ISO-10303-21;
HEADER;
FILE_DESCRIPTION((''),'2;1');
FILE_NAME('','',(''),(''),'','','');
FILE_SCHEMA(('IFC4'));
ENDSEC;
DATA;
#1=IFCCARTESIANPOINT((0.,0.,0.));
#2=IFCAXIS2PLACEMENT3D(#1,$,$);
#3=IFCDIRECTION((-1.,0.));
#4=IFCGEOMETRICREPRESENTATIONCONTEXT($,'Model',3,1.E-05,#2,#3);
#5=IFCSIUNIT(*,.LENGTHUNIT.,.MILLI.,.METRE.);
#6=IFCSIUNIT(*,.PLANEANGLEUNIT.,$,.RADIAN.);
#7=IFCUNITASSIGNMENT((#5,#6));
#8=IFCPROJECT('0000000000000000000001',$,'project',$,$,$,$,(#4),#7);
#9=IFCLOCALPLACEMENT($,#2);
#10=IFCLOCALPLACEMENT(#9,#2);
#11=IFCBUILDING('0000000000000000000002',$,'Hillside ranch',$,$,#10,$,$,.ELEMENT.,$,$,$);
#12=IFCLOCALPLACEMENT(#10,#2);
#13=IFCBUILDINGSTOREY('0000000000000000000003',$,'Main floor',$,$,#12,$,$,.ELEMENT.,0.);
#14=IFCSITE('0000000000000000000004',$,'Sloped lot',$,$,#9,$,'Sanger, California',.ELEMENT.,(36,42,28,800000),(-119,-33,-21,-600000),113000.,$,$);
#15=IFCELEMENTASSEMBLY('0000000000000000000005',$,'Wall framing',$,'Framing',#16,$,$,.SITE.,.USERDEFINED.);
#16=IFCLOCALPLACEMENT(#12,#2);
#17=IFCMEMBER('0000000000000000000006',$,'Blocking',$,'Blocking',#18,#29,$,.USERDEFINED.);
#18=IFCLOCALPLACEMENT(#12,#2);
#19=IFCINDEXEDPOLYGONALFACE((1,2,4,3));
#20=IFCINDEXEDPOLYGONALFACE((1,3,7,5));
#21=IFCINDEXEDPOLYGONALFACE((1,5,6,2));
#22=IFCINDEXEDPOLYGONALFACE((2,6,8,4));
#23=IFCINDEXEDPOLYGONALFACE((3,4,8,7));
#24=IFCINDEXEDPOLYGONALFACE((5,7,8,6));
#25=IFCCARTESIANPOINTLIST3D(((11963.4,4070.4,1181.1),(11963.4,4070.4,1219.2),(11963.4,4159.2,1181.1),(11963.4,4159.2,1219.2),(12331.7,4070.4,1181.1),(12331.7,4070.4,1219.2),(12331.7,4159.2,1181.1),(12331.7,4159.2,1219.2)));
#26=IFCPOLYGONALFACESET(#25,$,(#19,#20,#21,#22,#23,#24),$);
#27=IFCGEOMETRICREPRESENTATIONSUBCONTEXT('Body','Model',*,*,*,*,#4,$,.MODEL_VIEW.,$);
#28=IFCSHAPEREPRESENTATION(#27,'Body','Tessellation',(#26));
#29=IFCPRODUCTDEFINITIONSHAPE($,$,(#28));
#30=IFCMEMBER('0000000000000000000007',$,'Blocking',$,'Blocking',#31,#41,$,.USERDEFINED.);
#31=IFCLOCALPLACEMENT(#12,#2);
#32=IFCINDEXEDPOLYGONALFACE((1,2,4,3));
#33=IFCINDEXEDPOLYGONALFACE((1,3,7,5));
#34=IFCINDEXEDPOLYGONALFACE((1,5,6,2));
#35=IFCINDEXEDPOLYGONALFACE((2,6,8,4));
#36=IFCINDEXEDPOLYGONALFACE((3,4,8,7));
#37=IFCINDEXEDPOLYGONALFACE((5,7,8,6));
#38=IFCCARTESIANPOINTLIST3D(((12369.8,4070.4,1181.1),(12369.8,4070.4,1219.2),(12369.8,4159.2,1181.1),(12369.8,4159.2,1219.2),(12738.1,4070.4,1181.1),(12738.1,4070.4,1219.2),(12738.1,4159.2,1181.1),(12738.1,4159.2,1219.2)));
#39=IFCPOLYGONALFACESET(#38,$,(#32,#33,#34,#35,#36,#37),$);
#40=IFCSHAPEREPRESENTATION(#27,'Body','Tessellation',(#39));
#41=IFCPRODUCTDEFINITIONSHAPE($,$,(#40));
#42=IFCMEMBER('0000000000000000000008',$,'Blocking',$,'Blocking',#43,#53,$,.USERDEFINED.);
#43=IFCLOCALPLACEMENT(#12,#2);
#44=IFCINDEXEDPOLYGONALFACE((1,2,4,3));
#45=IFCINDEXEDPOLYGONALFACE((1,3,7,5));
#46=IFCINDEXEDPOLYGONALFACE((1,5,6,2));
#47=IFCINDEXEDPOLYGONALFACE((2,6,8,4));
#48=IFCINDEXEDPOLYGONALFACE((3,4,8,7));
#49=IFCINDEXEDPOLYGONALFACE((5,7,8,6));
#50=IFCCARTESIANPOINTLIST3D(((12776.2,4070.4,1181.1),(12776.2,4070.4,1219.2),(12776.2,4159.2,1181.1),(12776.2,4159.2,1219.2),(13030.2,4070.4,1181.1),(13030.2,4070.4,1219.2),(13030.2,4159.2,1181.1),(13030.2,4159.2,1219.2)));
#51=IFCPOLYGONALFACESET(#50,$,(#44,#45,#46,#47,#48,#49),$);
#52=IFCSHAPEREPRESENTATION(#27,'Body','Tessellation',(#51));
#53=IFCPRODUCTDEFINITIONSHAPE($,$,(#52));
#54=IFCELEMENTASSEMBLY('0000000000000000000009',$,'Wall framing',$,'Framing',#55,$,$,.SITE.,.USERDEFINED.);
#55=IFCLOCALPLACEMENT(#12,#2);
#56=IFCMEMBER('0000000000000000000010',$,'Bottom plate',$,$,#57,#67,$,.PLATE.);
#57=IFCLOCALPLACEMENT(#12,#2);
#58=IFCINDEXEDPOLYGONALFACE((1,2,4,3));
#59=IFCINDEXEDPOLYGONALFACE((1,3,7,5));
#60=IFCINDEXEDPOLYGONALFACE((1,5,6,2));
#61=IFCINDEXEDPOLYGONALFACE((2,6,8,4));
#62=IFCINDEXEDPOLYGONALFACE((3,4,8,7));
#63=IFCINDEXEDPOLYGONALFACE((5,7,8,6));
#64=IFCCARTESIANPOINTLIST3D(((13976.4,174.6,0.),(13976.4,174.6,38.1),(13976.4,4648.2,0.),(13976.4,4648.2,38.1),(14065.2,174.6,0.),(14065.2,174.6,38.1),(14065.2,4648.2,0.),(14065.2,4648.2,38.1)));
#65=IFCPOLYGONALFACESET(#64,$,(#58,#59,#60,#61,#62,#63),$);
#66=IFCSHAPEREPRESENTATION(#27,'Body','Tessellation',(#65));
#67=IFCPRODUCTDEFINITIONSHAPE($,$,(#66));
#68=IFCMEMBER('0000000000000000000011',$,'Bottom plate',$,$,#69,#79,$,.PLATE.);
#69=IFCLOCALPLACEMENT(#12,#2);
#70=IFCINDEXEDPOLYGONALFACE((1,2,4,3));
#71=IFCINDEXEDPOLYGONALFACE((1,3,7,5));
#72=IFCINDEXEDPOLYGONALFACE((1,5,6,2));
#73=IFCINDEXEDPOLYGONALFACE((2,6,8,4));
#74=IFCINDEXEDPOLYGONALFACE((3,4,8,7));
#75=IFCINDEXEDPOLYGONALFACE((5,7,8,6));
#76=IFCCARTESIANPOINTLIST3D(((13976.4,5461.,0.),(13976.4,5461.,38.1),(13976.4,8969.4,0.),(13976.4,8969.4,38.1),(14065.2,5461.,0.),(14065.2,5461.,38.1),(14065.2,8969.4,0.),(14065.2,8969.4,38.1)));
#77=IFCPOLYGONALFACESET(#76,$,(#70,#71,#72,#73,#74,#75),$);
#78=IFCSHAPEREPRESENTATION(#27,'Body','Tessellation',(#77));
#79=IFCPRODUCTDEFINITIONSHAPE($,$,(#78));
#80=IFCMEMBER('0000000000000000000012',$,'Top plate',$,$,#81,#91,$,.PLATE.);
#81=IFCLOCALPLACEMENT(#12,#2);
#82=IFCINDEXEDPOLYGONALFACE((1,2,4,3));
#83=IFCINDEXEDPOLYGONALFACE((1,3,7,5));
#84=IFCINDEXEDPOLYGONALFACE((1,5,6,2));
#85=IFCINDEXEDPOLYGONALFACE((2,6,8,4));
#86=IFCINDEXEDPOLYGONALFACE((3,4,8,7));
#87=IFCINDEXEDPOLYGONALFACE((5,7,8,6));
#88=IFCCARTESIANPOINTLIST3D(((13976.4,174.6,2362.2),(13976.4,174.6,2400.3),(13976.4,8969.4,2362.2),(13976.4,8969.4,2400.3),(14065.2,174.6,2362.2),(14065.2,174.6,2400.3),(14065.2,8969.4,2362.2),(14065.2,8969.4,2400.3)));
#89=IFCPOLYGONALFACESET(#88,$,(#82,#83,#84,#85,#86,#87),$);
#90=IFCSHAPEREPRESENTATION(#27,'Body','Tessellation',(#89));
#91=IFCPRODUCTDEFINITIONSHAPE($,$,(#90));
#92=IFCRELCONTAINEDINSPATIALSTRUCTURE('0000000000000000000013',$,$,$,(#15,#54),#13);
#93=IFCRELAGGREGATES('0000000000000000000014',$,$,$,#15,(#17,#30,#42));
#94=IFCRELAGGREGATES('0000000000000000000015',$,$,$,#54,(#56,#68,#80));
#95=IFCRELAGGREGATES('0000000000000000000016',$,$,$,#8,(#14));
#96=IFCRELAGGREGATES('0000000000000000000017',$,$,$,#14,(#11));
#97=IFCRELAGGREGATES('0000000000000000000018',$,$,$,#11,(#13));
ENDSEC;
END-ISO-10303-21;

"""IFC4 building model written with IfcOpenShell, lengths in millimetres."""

from ifc_helpers import new_model, si_unit, direction, frame, origin, origin_with_axes, place, context, subcontext, project, spatial, polyline, outline, extrude, element, aggregate, save


model = new_model("IFC4")

# Units and contexts
model_context = context("Model", 3, precision=1e-05, world=origin(), true_north=direction((-1.0, 0.0)))
body_context = subcontext(model_context, "Body", "Model", "MODEL_VIEW")
ifc_project = project(units=[si_unit("LENGTHUNIT", "METRE", prefix="MILLI"), si_unit("PLANEANGLEUNIT", "RADIAN")], contexts=[model_context])

# Site, building, storey
site_placement = place(None, origin())
site = spatial("IfcSite", under=ifc_project, at=site_placement, Name="Sloped lot", LongName="Sanger, California", CompositionType="ELEMENT", RefLatitude=(36, 42, 28, 800000), RefLongitude=(-119, -33, -21, -600000), RefElevation=113000.0)
building_placement = place(site_placement, origin())
building = spatial("IfcBuilding", under=site, at=building_placement, Name="Hillside ranch", CompositionType="ELEMENT")
storey_placement = place(building_placement, origin())
storey = spatial("IfcBuildingStorey", under=building, at=storey_placement, Name="Main floor", CompositionType="ELEMENT", Elevation=0.0)

# Element assemblies, members
assembly_1_placement = place(storey_placement, origin_with_axes())
assembly_1 = element("IfcElementAssembly", 1, at=assembly_1_placement, inside=storey, Name="Wall framing", ObjectType="Framing", AssemblyPlace="SITE", PredefinedType="USERDEFINED")
member_1_placement = place(storey_placement, origin_with_axes())
member_1 = element("IfcMember", 2, at=member_1_placement, Name="Blocking", ObjectType="Blocking", PredefinedType="USERDEFINED", context=body_context, shape_type="SweptSolid", body=[
    extrude(outline(polyline([(0.0, 0.0), (368.3, 0.0), (368.3, 88.9), (0.0, 88.9), (0.0, 0.0)])), frame((11963.4, 4070.3, 1181.1), z_axis=(0.0, 0.0, 1.0), x_axis=(1.0, 0.0, 0.0)), (0.0, 0.0, 1.0), 38.1),
])
member_2_placement = place(storey_placement, origin_with_axes())
member_2 = element("IfcMember", 3, at=member_2_placement, Name="Blocking", ObjectType="Blocking", PredefinedType="USERDEFINED", context=body_context, shape_type="SweptSolid", body=[
    extrude(outline(polyline([(0.0, 0.0), (368.3, 0.0), (368.3, 88.9), (0.0, 88.9), (0.0, 0.0)])), frame((12369.8, 4070.3, 1181.1), z_axis=(0.0, 0.0, 1.0), x_axis=(1.0, 0.0, 0.0)), (0.0, 0.0, 1.0), 38.1),
])
member_3_placement = place(storey_placement, origin_with_axes())
member_3 = element("IfcMember", 4, at=member_3_placement, Name="Blocking", ObjectType="Blocking", PredefinedType="USERDEFINED", context=body_context, shape_type="SweptSolid", body=[
    extrude(outline(polyline([(0.0, 0.0), (254.0, 0.0), (254.0, 88.9), (0.0, 88.9), (0.0, 0.0)])), frame((12776.2, 4070.3, 1181.1), z_axis=(0.0, 0.0, 1.0), x_axis=(1.0, 0.0, 0.0)), (0.0, 0.0, 1.0), 38.1),
])
aggregate(assembly_1, [member_1, member_2, member_3])
assembly_2_placement = place(storey_placement, origin_with_axes())
assembly_2 = element("IfcElementAssembly", 5, at=assembly_2_placement, inside=storey, Name="Wall framing", ObjectType="Framing", AssemblyPlace="SITE", PredefinedType="USERDEFINED")
member_4_placement = place(storey_placement, origin_with_axes())
member_4 = element("IfcMember", 6, at=member_4_placement, Name="Bottom plate", PredefinedType="PLATE", context=body_context, shape_type="SweptSolid", body=[
    extrude(outline(polyline([(0.0, 0.0), (4473.6, 0.0), (4473.6, 88.9), (0.0, 88.9), (0.0, 0.0)])), frame((14065.2, 174.6, 0.0), z_axis=(0.0, 0.0, 1.0), x_axis=(0.0, 1.0, 0.0)), (0.0, 0.0, 1.0), 38.1),
])
member_5_placement = place(storey_placement, origin_with_axes())
member_5 = element("IfcMember", 7, at=member_5_placement, Name="Bottom plate", PredefinedType="PLATE", context=body_context, shape_type="SweptSolid", body=[
    extrude(outline(polyline([(0.0, 0.0), (3508.4, 0.0), (3508.4, 88.9), (0.0, 88.9), (0.0, 0.0)])), frame((14065.2, 5461.0, 0.0), z_axis=(0.0, 0.0, 1.0), x_axis=(0.0, 1.0, 0.0)), (0.0, 0.0, 1.0), 38.1),
])
member_6_placement = place(storey_placement, origin_with_axes())
member_6 = element("IfcMember", 8, at=member_6_placement, Name="Top plate", PredefinedType="PLATE", context=body_context, shape_type="SweptSolid", body=[
    extrude(outline(polyline([(0.0, 0.0), (8794.8, 0.0), (8794.8, 88.9), (0.0, 88.9), (0.0, 0.0)])), frame((14065.2, 174.6, 2362.2), z_axis=(0.0, 0.0, 1.0), x_axis=(0.0, 1.0, 0.0)), (0.0, 0.0, 1.0), 38.1),
])
aggregate(assembly_2, [member_4, member_5, member_6])

save(model, "model.ifc")
